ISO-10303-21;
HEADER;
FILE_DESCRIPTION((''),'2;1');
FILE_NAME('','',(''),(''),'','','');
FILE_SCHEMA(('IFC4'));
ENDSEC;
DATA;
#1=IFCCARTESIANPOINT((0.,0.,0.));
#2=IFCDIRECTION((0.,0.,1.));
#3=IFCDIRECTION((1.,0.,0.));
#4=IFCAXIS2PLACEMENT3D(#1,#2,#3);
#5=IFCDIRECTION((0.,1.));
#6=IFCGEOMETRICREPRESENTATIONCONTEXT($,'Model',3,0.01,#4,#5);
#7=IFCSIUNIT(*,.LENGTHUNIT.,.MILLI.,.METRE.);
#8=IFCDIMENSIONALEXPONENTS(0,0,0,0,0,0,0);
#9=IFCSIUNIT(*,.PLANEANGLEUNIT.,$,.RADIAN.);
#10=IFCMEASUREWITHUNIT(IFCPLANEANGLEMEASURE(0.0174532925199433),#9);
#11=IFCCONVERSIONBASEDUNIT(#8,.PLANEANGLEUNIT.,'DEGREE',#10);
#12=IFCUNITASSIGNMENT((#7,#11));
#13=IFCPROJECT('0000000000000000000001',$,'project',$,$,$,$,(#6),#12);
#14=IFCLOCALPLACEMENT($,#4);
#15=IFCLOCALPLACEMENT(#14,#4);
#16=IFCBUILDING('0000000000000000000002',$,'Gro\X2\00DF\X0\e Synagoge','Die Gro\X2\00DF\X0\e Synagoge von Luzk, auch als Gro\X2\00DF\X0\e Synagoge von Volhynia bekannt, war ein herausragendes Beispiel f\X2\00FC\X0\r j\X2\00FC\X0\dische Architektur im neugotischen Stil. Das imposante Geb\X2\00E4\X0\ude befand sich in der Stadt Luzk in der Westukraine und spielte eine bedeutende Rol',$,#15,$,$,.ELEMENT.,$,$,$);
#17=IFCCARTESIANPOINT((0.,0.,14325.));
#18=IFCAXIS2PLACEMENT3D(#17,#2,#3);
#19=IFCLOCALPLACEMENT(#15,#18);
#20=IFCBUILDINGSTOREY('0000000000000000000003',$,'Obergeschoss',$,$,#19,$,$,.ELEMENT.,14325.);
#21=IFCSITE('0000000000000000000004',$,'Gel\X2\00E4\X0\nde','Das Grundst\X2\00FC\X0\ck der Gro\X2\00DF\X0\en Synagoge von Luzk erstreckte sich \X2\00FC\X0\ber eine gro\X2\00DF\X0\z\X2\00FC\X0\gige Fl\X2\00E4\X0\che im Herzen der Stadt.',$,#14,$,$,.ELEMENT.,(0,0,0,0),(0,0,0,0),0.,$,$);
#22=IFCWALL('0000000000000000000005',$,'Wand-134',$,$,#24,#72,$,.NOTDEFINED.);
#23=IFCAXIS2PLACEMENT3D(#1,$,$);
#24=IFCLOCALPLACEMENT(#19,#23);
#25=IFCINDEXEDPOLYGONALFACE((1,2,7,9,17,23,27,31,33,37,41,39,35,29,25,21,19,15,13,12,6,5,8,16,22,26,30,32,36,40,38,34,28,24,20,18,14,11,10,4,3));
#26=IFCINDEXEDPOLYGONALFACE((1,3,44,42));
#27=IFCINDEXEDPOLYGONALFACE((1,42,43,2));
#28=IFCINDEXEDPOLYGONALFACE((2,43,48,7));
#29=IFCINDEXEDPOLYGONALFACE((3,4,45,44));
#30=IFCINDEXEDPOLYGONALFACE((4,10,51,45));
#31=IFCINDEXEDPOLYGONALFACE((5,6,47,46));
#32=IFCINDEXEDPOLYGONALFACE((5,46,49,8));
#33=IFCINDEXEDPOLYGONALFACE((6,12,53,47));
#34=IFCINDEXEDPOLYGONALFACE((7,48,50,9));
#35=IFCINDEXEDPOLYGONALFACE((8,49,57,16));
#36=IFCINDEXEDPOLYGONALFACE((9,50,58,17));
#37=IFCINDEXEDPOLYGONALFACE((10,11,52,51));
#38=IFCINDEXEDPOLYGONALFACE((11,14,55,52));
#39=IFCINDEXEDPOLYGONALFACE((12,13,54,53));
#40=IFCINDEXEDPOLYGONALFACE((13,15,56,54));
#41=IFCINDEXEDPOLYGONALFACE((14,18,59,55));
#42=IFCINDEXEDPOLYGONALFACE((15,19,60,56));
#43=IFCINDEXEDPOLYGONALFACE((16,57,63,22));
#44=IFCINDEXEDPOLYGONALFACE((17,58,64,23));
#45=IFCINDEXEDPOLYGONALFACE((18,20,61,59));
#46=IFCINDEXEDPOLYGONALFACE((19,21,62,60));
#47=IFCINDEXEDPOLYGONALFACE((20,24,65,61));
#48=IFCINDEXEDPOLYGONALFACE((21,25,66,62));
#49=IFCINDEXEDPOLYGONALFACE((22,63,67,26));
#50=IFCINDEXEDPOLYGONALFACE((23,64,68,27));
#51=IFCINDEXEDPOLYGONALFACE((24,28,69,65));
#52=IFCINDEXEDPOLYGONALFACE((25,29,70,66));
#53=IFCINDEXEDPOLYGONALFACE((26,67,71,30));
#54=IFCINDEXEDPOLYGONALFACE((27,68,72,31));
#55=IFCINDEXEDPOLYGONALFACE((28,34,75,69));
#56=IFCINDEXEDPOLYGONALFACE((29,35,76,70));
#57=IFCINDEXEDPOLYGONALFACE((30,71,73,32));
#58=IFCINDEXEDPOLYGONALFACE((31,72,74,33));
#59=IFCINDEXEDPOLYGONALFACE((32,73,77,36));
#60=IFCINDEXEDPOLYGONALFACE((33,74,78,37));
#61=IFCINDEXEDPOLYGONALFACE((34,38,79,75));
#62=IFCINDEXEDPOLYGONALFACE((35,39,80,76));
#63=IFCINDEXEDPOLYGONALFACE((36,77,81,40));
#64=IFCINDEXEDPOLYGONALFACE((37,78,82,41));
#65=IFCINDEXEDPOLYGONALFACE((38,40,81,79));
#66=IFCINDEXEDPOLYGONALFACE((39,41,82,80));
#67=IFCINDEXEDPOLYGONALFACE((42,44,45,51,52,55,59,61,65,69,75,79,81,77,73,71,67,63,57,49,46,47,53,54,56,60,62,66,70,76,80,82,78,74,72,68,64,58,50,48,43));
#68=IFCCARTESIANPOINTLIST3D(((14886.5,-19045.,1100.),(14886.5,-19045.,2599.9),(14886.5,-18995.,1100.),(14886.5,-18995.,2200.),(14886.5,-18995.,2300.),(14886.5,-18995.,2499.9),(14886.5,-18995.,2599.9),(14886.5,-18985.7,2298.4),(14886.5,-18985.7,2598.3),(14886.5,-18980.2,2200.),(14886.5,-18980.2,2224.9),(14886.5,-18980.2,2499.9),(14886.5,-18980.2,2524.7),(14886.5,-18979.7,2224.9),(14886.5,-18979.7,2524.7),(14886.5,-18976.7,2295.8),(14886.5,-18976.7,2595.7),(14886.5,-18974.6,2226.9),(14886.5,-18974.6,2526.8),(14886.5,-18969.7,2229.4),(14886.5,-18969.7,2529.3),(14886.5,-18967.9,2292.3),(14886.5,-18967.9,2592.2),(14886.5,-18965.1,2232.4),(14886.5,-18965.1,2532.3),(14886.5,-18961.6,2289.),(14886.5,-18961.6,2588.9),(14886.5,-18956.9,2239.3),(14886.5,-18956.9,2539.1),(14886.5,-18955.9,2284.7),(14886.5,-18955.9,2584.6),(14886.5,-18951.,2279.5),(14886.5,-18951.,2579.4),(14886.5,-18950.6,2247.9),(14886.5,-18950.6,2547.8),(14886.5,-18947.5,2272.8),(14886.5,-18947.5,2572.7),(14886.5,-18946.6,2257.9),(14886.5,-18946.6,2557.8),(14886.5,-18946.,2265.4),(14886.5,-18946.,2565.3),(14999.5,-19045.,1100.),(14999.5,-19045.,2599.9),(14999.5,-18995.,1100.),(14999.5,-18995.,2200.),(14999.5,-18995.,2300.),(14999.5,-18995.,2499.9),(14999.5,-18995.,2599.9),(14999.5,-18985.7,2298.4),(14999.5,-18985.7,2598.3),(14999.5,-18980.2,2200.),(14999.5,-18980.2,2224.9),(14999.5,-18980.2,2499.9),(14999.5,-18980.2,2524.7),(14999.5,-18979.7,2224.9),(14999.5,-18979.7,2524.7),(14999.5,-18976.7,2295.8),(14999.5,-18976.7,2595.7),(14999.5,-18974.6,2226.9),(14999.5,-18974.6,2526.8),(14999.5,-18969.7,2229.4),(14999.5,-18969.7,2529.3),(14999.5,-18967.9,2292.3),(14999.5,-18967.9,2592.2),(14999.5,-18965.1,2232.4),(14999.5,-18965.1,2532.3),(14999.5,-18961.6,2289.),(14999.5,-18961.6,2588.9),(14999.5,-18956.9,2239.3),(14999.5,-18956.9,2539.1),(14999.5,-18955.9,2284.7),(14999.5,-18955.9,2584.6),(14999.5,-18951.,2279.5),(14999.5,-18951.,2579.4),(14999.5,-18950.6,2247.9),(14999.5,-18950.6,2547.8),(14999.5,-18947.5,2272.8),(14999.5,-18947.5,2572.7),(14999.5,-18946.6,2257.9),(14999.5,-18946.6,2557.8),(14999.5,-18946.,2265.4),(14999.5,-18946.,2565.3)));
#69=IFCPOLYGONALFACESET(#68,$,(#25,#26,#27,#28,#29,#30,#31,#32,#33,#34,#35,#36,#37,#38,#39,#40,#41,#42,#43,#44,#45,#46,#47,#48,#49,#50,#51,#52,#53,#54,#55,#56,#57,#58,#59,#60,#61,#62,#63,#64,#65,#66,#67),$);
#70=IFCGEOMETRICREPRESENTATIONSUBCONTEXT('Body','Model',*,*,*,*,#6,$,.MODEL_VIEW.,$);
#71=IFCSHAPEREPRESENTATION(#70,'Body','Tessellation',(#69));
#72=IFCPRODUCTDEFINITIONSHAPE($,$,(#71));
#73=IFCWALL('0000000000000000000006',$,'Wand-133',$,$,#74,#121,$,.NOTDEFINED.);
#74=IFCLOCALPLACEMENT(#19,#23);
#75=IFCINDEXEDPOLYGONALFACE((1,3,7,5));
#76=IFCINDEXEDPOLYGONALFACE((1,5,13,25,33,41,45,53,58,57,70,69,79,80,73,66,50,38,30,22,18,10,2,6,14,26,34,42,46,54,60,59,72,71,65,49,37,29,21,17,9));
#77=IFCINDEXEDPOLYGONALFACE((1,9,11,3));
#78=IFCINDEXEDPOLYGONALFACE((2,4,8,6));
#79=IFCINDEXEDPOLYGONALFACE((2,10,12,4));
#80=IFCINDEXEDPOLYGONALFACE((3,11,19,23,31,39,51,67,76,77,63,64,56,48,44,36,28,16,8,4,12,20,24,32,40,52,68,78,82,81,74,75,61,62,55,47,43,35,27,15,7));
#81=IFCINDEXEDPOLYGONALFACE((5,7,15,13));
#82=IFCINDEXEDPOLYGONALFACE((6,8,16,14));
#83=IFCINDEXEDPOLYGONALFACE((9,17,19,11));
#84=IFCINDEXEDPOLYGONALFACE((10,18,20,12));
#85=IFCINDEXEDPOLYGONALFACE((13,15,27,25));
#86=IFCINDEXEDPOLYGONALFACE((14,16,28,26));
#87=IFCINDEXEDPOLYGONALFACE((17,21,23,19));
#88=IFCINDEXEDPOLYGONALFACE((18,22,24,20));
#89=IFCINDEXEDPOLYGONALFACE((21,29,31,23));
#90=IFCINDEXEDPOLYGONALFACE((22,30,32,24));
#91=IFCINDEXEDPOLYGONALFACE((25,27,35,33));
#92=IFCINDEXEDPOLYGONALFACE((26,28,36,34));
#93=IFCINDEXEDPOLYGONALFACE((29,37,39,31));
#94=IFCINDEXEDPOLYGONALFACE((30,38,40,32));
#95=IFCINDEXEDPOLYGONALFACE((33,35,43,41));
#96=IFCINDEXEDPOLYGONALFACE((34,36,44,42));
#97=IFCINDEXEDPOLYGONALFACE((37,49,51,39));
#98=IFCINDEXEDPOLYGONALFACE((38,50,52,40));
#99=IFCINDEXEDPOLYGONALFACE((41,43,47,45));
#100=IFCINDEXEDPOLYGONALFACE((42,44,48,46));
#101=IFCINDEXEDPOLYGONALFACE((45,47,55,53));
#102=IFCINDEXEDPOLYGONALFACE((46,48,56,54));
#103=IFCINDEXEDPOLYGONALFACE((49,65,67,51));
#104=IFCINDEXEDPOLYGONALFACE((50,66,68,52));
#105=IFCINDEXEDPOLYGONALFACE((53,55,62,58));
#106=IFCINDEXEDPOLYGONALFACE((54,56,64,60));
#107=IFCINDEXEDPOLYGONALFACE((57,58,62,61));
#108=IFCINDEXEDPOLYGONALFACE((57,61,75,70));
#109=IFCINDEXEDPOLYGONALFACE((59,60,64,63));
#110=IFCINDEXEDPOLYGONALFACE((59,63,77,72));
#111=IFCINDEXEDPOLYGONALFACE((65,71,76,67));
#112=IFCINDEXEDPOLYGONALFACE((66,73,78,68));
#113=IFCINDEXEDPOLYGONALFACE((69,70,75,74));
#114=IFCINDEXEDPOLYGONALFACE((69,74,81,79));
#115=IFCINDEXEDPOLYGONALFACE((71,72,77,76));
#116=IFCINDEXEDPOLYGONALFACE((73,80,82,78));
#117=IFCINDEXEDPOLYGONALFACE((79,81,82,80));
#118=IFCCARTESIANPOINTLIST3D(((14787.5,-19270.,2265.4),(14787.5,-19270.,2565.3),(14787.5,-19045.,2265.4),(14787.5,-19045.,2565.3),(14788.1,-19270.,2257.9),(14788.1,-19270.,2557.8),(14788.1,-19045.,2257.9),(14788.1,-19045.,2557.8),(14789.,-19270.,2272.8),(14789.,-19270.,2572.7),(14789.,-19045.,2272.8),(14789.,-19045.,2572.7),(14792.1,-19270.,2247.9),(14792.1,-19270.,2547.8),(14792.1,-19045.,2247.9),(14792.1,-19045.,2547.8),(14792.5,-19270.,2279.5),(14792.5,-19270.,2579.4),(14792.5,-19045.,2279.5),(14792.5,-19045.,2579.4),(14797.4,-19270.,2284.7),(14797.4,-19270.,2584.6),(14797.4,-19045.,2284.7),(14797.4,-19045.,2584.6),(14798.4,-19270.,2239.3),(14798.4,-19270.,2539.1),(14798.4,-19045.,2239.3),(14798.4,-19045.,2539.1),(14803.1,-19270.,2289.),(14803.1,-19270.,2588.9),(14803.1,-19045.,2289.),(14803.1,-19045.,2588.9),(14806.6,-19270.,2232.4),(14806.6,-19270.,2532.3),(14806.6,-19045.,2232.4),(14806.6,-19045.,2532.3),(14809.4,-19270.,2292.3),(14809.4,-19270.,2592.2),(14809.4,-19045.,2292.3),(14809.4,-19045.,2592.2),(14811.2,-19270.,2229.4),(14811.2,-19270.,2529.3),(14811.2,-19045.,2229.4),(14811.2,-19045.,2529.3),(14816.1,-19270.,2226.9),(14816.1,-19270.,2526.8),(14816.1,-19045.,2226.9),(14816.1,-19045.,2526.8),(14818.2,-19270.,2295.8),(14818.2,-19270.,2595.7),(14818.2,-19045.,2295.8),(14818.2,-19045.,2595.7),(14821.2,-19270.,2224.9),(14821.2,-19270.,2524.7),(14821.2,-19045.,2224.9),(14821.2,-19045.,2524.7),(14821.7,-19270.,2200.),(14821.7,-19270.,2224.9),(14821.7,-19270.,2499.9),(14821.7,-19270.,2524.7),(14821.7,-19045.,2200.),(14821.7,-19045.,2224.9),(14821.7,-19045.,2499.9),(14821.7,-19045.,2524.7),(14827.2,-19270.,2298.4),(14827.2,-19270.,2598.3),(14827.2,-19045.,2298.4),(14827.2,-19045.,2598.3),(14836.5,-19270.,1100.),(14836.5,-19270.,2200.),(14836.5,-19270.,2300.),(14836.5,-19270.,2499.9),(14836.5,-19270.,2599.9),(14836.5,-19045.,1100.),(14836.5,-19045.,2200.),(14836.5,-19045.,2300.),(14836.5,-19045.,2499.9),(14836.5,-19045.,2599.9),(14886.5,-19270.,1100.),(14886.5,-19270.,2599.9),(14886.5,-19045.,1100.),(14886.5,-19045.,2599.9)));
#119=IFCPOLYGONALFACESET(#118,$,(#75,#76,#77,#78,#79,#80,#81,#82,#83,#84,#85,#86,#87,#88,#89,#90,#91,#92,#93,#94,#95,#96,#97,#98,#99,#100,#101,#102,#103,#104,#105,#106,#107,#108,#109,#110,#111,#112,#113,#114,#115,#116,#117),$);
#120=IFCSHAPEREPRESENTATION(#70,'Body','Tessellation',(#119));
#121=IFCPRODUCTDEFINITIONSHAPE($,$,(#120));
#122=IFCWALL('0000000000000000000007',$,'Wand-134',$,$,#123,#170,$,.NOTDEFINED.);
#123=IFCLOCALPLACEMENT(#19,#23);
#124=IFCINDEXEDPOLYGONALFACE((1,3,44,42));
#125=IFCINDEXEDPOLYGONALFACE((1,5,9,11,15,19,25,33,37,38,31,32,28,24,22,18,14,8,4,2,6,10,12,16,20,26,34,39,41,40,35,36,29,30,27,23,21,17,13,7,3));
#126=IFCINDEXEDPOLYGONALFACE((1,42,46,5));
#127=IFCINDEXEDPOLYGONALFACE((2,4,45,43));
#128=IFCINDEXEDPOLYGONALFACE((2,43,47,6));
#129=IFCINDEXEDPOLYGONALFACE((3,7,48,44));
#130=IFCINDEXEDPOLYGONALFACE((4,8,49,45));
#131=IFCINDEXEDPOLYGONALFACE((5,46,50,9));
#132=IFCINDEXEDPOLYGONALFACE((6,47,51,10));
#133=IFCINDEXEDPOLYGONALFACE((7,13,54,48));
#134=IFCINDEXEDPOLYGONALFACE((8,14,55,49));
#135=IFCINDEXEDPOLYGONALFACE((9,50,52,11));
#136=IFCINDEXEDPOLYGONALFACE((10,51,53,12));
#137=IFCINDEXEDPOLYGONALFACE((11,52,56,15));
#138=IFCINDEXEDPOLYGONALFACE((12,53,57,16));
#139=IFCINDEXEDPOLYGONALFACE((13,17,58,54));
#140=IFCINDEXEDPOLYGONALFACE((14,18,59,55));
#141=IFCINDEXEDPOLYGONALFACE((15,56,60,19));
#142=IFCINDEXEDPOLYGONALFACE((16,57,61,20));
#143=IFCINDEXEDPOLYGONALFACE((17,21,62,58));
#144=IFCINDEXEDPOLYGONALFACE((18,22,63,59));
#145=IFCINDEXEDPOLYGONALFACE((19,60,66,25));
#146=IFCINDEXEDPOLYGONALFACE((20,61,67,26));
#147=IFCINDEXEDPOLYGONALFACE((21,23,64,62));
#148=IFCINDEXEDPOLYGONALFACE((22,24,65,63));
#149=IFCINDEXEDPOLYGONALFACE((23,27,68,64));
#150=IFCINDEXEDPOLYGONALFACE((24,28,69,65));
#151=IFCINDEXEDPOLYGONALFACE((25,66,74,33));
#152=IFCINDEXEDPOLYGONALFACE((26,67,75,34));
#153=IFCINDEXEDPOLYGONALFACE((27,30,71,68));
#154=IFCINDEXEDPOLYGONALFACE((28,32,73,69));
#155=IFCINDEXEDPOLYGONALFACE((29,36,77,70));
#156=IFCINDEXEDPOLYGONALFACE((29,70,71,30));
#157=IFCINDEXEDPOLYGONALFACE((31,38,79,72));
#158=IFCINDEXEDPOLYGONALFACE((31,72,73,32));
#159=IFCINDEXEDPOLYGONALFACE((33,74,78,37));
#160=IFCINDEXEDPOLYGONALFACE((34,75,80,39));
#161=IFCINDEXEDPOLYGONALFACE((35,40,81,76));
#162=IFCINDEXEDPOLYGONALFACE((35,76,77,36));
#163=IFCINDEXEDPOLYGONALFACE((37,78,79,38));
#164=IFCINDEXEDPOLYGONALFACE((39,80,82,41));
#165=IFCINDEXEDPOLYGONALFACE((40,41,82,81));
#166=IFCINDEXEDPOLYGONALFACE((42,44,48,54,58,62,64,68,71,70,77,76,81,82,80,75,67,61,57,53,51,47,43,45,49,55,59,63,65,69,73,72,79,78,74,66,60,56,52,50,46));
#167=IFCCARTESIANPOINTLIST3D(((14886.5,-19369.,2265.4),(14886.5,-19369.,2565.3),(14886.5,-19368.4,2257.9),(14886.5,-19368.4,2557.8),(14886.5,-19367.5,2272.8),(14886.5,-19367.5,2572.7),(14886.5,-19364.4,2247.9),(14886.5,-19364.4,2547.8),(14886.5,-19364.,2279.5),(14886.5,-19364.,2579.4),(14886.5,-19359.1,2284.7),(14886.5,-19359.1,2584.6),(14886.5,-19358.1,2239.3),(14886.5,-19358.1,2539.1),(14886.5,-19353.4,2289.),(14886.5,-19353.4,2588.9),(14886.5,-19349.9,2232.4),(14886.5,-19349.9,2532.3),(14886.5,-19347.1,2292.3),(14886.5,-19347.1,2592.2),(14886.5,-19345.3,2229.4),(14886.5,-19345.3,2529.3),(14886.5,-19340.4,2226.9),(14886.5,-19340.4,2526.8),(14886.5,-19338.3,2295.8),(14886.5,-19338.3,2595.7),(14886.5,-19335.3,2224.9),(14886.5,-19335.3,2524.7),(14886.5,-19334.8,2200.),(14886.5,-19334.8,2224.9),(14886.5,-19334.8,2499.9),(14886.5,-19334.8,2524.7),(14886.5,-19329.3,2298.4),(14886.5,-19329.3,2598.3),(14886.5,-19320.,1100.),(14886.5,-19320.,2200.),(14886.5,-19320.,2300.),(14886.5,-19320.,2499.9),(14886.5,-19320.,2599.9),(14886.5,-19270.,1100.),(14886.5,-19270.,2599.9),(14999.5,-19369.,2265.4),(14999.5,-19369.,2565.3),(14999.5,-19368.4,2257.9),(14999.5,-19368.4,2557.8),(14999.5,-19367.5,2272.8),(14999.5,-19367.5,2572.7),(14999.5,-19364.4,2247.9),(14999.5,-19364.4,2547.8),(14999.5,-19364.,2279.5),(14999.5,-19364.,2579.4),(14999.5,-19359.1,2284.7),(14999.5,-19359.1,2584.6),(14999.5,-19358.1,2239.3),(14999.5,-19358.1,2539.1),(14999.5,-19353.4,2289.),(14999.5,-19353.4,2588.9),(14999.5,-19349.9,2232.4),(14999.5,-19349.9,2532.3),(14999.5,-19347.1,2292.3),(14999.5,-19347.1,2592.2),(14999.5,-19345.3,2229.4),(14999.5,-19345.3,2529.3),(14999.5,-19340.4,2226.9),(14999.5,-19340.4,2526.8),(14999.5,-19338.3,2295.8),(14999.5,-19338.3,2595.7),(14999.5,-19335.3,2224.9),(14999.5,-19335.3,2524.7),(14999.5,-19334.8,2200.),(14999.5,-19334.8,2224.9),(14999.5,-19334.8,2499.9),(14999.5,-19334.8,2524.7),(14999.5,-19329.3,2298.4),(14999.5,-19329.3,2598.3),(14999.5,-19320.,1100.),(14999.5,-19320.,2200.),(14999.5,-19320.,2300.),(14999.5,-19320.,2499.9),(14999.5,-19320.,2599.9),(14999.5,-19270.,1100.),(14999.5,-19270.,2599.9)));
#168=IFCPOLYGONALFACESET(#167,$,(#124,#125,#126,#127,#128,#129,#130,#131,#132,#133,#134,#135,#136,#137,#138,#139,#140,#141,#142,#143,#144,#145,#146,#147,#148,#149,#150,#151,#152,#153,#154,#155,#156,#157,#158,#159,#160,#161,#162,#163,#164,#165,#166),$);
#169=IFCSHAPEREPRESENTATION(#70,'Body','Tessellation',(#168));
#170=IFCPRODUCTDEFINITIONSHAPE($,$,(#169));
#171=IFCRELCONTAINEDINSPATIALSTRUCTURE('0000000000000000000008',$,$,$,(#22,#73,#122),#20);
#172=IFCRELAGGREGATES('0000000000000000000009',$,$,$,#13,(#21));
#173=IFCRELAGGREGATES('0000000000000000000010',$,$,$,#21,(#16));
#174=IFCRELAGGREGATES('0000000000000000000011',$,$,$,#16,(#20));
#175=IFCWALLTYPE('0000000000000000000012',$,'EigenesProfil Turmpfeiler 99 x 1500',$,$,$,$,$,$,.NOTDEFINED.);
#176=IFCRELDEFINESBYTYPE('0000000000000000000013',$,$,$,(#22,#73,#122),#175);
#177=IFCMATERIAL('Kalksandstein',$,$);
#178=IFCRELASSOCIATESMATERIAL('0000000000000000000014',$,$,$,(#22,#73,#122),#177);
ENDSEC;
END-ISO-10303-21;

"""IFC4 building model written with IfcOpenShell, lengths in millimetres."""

from ifc_helpers import new_model, entity, si_unit, converted_unit, direction, frame, origin_with_axes, place, context, subcontext, project, spatial, line, arc, indexed_curve, outline, extrude, material, material_profile, profile_set, type_object, element, save


model = new_model("IFC4")

# Units and contexts
model_context = context("Model", 3, precision=0.01, world=origin_with_axes(), true_north=direction((0.0, 1.0)))
body_context = subcontext(model_context, "Body", "Model", "MODEL_VIEW")
ifc_project = project(units=[si_unit("LENGTHUNIT", "METRE", prefix="MILLI"), converted_unit("PLANEANGLEUNIT", "DEGREE", entity("IfcPlaneAngleMeasure", 0.0174532925199433), si_unit("PLANEANGLEUNIT", "RADIAN"), dimensions=[0, 0, 0, 0, 0, 0, 0])], contexts=[model_context])

# Site, building, storey
site_placement = place(None, origin_with_axes())
site = spatial("IfcSite", under=ifc_project, at=site_placement, Name="Gelände", Description="Das Grundstück der Großen Synagoge von Luzk erstreckte sich über eine großzügige Fläche im Herzen der Stadt.", CompositionType="ELEMENT", RefLatitude=(0, 0, 0, 0), RefLongitude=(0, 0, 0, 0), RefElevation=0.0)
building_placement = place(site_placement, origin_with_axes())
building = spatial("IfcBuilding", under=site, at=building_placement, Name="Große Synagoge", Description="Die Große Synagoge von Luzk, auch als Große Synagoge von Volhynia bekannt, war ein herausragendes Beispiel für jüdische Architektur im neugotischen Stil. Das imposante Gebäude befand sich in der Stadt Luzk in der Westukraine und spielte eine bedeutende Rol", CompositionType="ELEMENT")
storey_placement = place(building_placement, frame((0.0, 0.0, 14325.0), z_axis=(0.0, 0.0, 1.0), x_axis=(1.0, 0.0, 0.0)))
storey = spatial("IfcBuildingStorey", under=building, at=storey_placement, Name="Obergeschoss", CompositionType="ELEMENT", Elevation=14325.0)

# Shared definitions
ifc_material_1 = material(Name="Kalksandstein")

# Walls
ifc_material_profile_1 = material_profile(ifc_material_1, outline(indexed_curve([(65.3, 1424.7), (72.9, 1428.0), (79.9, 1432.3), (91.6, 1443.3), (98.4, 1457.8), (98.5, 1469.1), (94.0, 1479.4), (86.3, 1486.9), (77.1, 1492.2), (63.8, 1497.1), (50.0, 1499.9), (0.0, 1499.9), (0.0, 0.0), (50.0, 0.0), (50.0, 1100.0), (64.8, 1100.0), (64.8, 1124.9), (65.3, 1124.9), (72.9, 1128.1), (79.9, 1132.4), (91.6, 1143.4), (98.4, 1157.9), (98.5, 1169.2), (94.0, 1179.5), (86.3, 1187.0), (77.1, 1192.3), (63.8, 1197.2), (50.0, 1200.0), (50.0, 1399.9), (64.8, 1399.9), (64.8, 1424.7)], segments=[arc(1, 2, 3), arc(3, 4, 5), arc(5, 6, 7), arc(7, 8, 9), arc(9, 10, 11), line(11, 12, 13, 14, 15, 16, 17, 18), arc(18, 19, 20), arc(20, 21, 22), arc(22, 23, 24), arc(24, 25, 26), arc(26, 27, 28), line(28, 29, 30, 31, 1)])), Name="Kalksandstein")
ifc_profile_set_1 = profile_set([ifc_material_profile_1], Name="EigenesProfil Turmpfeiler")
wall_type_1 = type_object("IfcWallType", Name="EigenesProfil Turmpfeiler 99 x 1500", PredefinedType="NOTDEFINED")
wall_1_placement = place(storey_placement, frame((14886.5, -19045.0, 1100.0), z_axis=(0.0, 0.0, 1.0), x_axis=(1.0, 0.0, 0.0)))
element("IfcWall", 1, at=wall_1_placement, inside=storey, type_object=wall_type_1, material=ifc_profile_set_1, Name="Wand-134", PredefinedType="NOTDEFINED", context=body_context, shape_type="SweptSolid", body=[
    extrude(outline(indexed_curve([(65.3, 1424.7), (72.9, 1428.0), (79.9, 1432.3), (91.6, 1443.3), (98.4, 1457.8), (98.5, 1469.1), (94.0, 1479.4), (86.3, 1486.9), (77.1, 1492.2), (63.8, 1497.1), (50.0, 1499.9), (0.0, 1499.9), (0.0, 0.0), (50.0, 0.0), (50.0, 1100.0), (64.8, 1100.0), (64.8, 1124.9), (65.3, 1124.9), (72.9, 1128.1), (79.9, 1132.4), (91.6, 1143.4), (98.4, 1157.9), (98.5, 1169.2), (94.0, 1179.5), (86.3, 1187.0), (77.1, 1192.3), (63.8, 1197.2), (50.0, 1200.0), (50.0, 1399.9), (64.8, 1399.9), (64.8, 1424.7)], segments=[arc(1, 2, 3), arc(3, 4, 5), arc(5, 6, 7), arc(7, 8, 9), arc(9, 10, 11), line(11, 12, 13, 14, 15, 16, 17, 18), arc(18, 19, 20), arc(20, 21, 22), arc(22, 23, 24), arc(24, 25, 26), arc(26, 27, 28), line(28, 29, 30, 31, 1)])), frame((0.0, 0.0, 0.0), z_axis=(1.0, 0.0, 0.0), x_axis=(0.0, 1.0, 0.0)), (0.0, 0.0, 1.0), 113.0),
])
wall_2_placement = place(storey_placement, frame((14886.5, -19270.0, 1100.0), z_axis=(0.0, 0.0, 1.0), x_axis=(0.0, 1.0, 0.0)))
element("IfcWall", 2, at=wall_2_placement, inside=storey, type_object=wall_type_1, material=ifc_profile_set_1, Name="Wand-133", PredefinedType="NOTDEFINED", context=body_context, shape_type="SweptSolid", body=[
    extrude(outline(indexed_curve([(65.3, 1424.7), (72.9, 1428.0), (79.9, 1432.3), (91.6, 1443.3), (98.4, 1457.8), (98.5, 1469.1), (94.0, 1479.4), (86.3, 1486.9), (77.1, 1492.2), (63.8, 1497.1), (50.0, 1499.9), (0.0, 1499.9), (0.0, 0.0), (50.0, 0.0), (50.0, 1100.0), (64.8, 1100.0), (64.8, 1124.9), (65.3, 1124.9), (72.9, 1128.1), (79.9, 1132.4), (91.6, 1143.4), (98.4, 1157.9), (98.5, 1169.2), (94.0, 1179.5), (86.3, 1187.0), (77.1, 1192.3), (63.8, 1197.2), (50.0, 1200.0), (50.0, 1399.9), (64.8, 1399.9), (64.8, 1424.7)], segments=[arc(1, 2, 3), arc(3, 4, 5), arc(5, 6, 7), arc(7, 8, 9), arc(9, 10, 11), line(11, 12, 13, 14, 15, 16, 17, 18), arc(18, 19, 20), arc(20, 21, 22), arc(22, 23, 24), arc(24, 25, 26), arc(26, 27, 28), line(28, 29, 30, 31, 1)])), frame((0.0, 0.0, 0.0), z_axis=(1.0, 0.0, 0.0), x_axis=(0.0, 1.0, 0.0)), (0.0, 0.0, 1.0), 225.0),
])
wall_3_placement = place(storey_placement, frame((14886.5, -19270.0, 1100.0), z_axis=(0.0, 0.0, 1.0), x_axis=(1.0, 0.0, 0.0)))
element("IfcWall", 3, at=wall_3_placement, inside=storey, type_object=wall_type_1, material=ifc_profile_set_1, Name="Wand-134", PredefinedType="NOTDEFINED", context=body_context, shape_type="SweptSolid", body=[
    extrude(outline(indexed_curve([(65.3, 1424.7), (72.9, 1428.0), (79.9, 1432.3), (91.6, 1443.3), (98.4, 1457.8), (98.5, 1469.1), (94.0, 1479.4), (86.3, 1486.9), (77.1, 1492.2), (63.8, 1497.1), (50.0, 1499.9), (0.0, 1499.9), (0.0, 0.0), (50.0, 0.0), (50.0, 1100.0), (64.8, 1100.0), (64.8, 1124.9), (65.3, 1124.9), (72.9, 1128.1), (79.9, 1132.4), (91.6, 1143.4), (98.4, 1157.9), (98.5, 1169.2), (94.0, 1179.5), (86.3, 1187.0), (77.1, 1192.3), (63.8, 1197.2), (50.0, 1200.0), (50.0, 1399.9), (64.8, 1399.9), (64.8, 1424.7)], segments=[arc(1, 2, 3), arc(3, 4, 5), arc(5, 6, 7), arc(7, 8, 9), arc(9, 10, 11), line(11, 12, 13, 14, 15, 16, 17, 18), arc(18, 19, 20), arc(20, 21, 22), arc(22, 23, 24), arc(24, 25, 26), arc(26, 27, 28), line(28, 29, 30, 31, 1)])), frame((0.0, 0.0, 0.0), z_axis=(-1.0, 0.0, 0.0), x_axis=(0.0, -1.0, 0.0)), (0.0, 0.0, -1.0), 113.0),
])

save(model, "model.ifc")
